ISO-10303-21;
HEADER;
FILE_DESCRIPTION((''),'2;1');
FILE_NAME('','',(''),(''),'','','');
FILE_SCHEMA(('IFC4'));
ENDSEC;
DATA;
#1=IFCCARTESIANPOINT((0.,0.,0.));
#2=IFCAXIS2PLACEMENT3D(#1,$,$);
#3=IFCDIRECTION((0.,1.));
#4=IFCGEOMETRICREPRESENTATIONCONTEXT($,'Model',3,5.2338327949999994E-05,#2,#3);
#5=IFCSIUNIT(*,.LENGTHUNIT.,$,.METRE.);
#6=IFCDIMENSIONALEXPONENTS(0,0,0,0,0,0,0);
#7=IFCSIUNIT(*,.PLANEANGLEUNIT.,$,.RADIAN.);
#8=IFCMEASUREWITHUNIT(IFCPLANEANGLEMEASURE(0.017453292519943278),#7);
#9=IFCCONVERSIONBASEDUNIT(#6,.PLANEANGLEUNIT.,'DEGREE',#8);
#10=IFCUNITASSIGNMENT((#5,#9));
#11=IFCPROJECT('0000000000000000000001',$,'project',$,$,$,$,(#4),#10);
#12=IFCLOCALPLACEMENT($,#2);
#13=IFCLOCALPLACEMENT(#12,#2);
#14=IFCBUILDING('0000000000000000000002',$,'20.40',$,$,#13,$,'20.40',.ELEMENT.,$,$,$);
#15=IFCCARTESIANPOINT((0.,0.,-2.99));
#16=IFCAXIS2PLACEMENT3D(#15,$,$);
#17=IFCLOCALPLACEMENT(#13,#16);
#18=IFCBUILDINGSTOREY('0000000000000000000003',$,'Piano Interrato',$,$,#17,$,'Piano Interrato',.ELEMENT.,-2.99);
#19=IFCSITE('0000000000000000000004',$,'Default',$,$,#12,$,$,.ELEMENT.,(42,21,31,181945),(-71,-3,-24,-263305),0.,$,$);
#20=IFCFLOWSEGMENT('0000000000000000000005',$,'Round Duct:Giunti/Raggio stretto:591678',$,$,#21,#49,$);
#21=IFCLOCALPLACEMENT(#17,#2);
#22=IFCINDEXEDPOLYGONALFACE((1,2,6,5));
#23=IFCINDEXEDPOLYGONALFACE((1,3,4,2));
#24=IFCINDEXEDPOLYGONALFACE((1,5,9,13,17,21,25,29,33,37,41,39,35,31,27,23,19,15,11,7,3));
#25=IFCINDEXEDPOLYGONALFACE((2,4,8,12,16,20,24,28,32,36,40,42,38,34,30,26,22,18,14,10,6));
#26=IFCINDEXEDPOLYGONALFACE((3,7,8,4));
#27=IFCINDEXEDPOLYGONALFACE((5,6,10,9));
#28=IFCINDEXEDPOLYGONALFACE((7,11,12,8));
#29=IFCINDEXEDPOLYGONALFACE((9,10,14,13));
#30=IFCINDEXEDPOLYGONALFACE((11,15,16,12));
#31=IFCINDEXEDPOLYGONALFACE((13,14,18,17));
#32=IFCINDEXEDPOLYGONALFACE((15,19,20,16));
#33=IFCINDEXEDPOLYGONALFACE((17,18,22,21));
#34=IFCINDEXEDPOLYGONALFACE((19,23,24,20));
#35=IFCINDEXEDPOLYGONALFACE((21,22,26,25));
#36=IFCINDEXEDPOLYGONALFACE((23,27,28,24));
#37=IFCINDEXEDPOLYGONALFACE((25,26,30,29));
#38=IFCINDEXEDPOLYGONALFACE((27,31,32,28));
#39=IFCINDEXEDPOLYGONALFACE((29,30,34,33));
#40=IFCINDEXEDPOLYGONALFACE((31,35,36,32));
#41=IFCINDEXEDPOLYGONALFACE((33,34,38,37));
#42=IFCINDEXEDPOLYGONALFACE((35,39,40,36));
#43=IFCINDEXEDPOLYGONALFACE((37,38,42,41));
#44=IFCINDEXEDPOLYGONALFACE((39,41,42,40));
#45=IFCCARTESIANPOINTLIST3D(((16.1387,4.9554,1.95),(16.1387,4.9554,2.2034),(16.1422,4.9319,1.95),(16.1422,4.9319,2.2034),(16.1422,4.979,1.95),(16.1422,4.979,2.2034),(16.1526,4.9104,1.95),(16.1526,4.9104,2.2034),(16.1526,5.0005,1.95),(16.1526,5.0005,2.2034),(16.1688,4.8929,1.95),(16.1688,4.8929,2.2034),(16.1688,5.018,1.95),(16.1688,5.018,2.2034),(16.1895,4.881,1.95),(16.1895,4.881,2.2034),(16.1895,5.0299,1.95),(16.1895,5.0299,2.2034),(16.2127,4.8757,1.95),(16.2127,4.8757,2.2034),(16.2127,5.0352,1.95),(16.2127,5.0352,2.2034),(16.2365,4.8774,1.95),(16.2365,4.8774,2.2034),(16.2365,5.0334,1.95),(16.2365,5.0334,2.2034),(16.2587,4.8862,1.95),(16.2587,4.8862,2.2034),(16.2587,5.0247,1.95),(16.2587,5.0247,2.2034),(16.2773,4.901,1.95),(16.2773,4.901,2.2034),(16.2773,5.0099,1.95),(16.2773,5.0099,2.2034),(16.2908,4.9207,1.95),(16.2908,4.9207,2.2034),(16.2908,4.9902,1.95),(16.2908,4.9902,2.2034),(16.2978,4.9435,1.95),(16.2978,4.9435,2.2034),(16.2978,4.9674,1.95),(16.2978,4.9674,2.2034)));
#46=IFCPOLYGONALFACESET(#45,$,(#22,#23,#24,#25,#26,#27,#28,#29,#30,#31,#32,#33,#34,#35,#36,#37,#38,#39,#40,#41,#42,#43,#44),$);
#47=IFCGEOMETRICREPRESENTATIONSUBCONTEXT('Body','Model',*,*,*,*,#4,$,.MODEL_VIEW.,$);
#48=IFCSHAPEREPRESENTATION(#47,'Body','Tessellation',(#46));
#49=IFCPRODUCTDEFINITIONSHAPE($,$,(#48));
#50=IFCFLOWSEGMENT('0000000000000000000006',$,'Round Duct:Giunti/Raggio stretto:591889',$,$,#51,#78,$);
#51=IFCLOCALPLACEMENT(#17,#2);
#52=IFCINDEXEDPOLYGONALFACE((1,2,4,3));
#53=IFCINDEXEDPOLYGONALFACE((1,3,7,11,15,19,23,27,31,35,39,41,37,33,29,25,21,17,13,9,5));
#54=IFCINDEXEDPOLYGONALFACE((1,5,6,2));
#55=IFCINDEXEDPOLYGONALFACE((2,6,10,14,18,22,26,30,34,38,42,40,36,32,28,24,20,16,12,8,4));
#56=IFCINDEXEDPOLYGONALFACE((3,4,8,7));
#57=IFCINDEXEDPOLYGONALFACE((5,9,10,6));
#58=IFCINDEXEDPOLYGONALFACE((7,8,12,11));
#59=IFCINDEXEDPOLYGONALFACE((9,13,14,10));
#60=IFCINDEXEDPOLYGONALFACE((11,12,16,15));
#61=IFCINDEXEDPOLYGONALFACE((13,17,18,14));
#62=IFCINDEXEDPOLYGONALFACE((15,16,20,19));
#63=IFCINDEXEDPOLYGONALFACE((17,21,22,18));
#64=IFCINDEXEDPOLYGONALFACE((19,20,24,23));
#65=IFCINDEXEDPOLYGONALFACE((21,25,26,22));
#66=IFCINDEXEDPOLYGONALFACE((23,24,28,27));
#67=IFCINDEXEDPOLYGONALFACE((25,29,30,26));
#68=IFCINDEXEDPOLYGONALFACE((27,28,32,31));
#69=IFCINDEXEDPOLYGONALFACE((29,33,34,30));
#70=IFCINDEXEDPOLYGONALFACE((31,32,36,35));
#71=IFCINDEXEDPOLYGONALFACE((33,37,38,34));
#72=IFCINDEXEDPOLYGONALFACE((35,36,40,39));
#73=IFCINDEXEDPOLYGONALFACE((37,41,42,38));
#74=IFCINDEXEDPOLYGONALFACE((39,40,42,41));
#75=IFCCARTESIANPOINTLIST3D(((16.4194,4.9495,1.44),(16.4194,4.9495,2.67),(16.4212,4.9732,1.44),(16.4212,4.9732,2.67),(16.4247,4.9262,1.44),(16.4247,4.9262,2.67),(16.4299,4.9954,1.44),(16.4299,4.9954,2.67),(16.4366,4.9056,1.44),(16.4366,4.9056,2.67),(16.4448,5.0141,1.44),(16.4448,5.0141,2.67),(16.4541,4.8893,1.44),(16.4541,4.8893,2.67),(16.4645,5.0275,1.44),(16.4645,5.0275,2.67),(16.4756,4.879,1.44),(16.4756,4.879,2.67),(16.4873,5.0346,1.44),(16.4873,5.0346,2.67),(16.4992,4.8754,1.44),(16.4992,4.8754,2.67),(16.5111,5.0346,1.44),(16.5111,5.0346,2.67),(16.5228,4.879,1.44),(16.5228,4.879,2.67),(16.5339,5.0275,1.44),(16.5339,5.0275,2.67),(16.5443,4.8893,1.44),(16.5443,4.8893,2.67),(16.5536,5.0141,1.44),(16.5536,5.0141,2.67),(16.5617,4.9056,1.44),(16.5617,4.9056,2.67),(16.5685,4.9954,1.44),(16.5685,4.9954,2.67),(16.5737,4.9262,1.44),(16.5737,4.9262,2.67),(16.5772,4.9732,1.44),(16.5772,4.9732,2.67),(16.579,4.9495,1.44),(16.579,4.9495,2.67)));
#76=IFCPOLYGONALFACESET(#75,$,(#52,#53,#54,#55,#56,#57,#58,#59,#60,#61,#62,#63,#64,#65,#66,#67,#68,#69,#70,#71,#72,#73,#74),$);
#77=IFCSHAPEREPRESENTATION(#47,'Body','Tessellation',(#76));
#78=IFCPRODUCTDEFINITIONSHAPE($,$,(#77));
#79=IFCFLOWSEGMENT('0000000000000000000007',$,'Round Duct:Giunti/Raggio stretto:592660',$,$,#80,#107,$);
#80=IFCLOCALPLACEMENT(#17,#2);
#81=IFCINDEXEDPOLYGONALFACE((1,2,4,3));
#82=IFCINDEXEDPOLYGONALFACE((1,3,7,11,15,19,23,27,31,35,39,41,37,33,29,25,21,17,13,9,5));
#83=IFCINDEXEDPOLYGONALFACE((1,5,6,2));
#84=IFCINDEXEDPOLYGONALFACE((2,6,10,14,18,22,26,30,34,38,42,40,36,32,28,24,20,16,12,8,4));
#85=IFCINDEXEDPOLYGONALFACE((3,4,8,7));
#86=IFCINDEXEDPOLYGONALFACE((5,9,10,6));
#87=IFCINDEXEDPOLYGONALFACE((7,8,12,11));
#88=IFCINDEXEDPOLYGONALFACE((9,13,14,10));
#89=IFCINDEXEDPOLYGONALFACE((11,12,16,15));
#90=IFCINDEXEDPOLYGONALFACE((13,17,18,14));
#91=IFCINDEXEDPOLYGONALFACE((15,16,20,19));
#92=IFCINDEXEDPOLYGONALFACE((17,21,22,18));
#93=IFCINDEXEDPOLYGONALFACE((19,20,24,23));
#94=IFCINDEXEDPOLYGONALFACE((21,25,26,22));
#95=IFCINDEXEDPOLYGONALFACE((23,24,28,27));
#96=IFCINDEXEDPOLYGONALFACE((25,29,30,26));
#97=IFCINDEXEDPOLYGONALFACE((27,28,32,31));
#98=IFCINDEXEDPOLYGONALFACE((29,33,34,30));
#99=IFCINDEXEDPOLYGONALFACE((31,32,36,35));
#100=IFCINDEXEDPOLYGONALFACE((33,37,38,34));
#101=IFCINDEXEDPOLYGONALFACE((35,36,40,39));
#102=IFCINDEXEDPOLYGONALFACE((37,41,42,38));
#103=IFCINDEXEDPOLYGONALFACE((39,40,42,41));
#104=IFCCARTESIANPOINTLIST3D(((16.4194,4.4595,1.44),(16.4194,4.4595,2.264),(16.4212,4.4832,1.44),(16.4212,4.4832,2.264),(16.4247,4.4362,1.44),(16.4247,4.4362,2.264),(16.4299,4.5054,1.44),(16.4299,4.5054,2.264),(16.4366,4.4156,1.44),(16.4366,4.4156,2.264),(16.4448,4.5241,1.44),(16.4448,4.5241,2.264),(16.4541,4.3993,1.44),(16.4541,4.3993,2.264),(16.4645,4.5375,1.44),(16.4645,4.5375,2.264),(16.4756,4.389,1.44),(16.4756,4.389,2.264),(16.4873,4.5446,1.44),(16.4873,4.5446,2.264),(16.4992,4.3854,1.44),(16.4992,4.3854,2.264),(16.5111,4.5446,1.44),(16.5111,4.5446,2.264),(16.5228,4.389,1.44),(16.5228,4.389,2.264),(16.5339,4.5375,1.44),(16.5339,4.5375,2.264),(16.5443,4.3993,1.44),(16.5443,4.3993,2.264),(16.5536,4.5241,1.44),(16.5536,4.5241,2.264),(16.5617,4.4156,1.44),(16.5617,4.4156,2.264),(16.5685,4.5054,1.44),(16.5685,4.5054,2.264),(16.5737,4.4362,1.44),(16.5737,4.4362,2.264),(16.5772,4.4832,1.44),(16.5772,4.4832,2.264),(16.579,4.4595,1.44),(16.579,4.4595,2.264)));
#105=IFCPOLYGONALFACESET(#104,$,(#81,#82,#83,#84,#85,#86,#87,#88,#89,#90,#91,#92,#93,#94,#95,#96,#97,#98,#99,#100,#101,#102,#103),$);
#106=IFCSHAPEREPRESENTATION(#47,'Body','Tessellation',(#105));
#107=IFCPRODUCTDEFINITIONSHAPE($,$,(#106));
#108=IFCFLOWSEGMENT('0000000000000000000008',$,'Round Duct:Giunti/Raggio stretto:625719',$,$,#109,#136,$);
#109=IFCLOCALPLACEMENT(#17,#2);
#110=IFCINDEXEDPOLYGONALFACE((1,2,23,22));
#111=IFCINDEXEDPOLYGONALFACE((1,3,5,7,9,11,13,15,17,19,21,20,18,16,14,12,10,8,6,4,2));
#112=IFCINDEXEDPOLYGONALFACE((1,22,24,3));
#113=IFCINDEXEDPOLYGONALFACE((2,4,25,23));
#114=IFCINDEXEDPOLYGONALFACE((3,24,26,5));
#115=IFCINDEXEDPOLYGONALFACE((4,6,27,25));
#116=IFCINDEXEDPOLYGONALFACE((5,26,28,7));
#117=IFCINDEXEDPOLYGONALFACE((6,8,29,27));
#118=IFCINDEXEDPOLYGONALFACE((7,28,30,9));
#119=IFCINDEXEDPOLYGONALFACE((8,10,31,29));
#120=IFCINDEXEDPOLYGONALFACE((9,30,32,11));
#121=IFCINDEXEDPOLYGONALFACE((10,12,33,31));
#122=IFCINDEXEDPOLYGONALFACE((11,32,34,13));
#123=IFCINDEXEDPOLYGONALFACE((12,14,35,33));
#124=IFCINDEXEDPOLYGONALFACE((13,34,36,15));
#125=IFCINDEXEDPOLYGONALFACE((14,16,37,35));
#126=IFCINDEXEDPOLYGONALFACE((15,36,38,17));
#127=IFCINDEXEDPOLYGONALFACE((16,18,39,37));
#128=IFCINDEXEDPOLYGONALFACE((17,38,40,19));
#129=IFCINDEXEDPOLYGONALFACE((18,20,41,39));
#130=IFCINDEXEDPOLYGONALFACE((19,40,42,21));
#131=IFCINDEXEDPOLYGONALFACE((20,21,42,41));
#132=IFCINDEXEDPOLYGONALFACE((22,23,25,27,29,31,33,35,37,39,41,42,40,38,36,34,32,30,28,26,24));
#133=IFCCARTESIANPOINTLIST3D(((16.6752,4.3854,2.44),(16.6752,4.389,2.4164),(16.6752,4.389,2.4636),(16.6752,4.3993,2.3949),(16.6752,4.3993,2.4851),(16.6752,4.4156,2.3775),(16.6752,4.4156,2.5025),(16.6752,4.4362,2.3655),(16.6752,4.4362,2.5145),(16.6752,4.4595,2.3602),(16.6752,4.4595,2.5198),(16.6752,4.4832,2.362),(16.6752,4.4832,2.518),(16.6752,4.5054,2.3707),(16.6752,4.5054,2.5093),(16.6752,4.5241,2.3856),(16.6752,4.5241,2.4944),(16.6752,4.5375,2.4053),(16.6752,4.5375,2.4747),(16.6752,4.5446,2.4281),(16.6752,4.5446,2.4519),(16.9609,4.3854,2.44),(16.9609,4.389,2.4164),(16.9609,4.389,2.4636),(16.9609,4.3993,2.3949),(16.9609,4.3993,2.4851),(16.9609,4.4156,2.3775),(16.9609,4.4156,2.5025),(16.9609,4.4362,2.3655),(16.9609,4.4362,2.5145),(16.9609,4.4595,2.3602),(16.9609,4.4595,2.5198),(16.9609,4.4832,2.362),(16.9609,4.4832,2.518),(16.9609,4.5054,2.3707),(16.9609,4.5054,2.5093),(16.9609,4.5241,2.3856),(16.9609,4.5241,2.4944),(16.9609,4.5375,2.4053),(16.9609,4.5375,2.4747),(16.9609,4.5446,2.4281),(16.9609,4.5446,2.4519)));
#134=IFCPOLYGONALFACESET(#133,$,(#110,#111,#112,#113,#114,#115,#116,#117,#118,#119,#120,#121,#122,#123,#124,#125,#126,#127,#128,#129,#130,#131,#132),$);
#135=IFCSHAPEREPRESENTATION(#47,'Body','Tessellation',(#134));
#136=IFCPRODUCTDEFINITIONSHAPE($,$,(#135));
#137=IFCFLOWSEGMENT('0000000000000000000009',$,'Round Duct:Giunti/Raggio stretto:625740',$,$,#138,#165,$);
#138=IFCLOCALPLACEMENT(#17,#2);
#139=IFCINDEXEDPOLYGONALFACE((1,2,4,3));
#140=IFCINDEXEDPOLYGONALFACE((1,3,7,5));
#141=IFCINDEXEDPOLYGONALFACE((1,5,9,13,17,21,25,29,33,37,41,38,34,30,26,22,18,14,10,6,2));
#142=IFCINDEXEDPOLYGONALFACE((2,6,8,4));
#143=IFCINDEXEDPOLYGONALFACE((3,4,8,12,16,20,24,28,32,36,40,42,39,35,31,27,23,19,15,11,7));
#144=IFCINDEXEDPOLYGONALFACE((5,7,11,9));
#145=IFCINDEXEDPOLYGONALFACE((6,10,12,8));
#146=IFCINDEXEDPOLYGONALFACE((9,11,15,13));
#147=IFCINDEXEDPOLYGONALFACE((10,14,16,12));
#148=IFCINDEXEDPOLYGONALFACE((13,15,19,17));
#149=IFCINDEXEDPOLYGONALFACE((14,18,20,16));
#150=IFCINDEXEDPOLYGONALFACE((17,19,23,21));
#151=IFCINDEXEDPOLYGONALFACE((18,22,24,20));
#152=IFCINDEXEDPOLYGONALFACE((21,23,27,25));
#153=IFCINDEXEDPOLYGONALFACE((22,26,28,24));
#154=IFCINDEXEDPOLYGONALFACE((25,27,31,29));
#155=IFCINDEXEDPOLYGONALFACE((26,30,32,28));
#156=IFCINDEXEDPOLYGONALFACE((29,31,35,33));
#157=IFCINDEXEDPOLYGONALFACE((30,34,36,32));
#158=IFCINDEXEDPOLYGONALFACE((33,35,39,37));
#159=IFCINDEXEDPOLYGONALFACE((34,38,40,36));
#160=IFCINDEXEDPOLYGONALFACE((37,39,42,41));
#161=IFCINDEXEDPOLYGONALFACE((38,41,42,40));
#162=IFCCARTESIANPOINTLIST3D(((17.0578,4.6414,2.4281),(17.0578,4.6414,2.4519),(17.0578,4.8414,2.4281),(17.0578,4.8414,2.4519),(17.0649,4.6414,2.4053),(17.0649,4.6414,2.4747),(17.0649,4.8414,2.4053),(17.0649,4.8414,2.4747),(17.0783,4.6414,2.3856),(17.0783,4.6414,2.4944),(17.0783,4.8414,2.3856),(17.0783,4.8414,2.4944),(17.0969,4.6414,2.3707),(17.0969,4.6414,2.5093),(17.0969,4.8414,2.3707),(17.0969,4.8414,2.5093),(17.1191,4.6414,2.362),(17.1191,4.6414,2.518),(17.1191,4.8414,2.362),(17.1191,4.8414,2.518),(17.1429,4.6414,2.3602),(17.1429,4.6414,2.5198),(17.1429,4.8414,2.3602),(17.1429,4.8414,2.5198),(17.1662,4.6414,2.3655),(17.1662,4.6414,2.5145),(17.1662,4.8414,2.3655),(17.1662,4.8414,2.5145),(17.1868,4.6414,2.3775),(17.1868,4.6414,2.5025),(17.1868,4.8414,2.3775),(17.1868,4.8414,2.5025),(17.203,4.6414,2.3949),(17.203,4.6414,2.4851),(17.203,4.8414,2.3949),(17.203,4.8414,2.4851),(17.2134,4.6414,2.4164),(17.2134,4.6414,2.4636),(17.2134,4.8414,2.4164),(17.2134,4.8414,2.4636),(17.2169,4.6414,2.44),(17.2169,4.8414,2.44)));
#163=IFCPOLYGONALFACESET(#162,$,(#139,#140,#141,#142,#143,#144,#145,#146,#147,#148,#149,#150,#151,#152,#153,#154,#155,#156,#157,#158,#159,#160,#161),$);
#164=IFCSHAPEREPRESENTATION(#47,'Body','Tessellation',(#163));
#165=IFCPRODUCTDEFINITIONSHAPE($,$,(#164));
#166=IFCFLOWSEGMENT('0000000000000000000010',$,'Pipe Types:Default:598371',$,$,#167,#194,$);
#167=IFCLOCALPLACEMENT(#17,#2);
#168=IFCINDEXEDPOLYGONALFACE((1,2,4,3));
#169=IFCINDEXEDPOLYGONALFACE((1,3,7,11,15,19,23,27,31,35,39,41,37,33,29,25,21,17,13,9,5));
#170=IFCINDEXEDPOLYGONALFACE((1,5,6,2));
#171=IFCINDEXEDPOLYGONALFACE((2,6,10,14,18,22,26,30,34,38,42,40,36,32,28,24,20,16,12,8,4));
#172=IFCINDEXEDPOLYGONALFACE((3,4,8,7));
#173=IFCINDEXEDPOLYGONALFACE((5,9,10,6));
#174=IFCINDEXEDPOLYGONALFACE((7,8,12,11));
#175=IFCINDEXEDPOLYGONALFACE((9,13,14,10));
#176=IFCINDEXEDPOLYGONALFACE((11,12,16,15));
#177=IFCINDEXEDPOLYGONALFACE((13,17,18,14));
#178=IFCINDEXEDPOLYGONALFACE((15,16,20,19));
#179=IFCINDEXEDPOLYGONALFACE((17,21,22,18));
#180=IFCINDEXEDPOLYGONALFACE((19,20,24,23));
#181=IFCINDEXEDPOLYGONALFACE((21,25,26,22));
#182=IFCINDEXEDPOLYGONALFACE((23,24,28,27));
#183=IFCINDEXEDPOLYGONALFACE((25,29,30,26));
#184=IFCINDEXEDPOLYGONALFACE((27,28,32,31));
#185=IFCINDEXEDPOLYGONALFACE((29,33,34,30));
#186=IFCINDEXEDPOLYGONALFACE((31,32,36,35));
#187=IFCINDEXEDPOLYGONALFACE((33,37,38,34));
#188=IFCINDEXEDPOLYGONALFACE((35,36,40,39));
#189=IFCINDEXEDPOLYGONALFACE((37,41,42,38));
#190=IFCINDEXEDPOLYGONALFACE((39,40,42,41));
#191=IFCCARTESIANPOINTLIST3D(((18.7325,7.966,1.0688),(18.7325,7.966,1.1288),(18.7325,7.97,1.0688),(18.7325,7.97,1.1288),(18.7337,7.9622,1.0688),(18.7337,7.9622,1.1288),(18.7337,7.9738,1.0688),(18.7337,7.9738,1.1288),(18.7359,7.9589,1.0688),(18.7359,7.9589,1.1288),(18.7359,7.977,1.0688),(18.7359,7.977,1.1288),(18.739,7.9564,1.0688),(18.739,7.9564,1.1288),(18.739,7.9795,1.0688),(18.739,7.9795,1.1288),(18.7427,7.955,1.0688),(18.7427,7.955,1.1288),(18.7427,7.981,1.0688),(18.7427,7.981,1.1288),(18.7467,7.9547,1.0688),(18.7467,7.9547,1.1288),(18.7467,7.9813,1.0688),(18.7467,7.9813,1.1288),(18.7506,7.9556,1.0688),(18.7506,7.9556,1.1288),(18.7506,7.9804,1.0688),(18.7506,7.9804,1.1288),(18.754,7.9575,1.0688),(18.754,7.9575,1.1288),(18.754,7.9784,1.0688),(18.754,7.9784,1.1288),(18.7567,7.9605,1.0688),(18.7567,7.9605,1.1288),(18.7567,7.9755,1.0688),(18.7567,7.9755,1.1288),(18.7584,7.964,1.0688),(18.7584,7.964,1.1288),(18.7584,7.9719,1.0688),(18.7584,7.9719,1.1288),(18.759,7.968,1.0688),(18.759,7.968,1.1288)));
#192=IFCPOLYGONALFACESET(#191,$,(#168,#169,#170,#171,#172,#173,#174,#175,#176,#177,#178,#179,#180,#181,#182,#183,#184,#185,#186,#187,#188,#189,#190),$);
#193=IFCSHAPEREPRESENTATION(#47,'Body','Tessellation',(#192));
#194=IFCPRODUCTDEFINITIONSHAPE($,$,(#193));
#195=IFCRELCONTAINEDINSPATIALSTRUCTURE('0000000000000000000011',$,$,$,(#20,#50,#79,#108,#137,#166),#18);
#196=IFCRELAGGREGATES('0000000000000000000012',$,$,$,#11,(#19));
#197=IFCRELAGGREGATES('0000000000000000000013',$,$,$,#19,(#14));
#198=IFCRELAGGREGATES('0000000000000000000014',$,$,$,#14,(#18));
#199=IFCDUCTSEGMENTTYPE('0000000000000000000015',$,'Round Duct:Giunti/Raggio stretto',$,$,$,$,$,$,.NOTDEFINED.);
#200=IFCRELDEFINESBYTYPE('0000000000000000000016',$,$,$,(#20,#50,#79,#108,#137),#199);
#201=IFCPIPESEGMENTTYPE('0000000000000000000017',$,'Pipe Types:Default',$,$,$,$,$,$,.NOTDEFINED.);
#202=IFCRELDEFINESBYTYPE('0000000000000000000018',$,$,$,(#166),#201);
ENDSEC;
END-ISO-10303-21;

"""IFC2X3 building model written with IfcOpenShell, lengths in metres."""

from ifc_helpers import new_model, entity, si_unit, converted_unit, direction, frame, frame_2d, origin, origin_2d_with_axis, place, context, subcontext, project, spatial, circle, extrude, type_object, element, save


model = new_model("IFC2X3")

# Units and contexts
model_context = context("Model", 3, precision=5.2338327949999994e-05, world=origin(), true_north=direction((0.0, 1.0)))
body_context = subcontext(model_context, "Body", "Model", "MODEL_VIEW")
ifc_project = project(units=[si_unit("LENGTHUNIT", "METRE"), converted_unit("PLANEANGLEUNIT", "DEGREE", entity("IfcPlaneAngleMeasure", 0.017453292519943278), si_unit("PLANEANGLEUNIT", "RADIAN"), dimensions=[0, 0, 0, 0, 0, 0, 0])], contexts=[model_context])

# Site, building, storey
site_placement = place(None, origin())
site = spatial("IfcSite", under=ifc_project, at=site_placement, Name="Default", CompositionType="ELEMENT", RefLatitude=(42, 21, 31, 181945), RefLongitude=(-71, -3, -24, -263305), RefElevation=0.0)
building_placement = place(site_placement, origin())
building = spatial("IfcBuilding", under=site, at=building_placement, Name="20.40", LongName="20.40", CompositionType="ELEMENT")
storey_placement = place(building_placement, frame((0.0, 0.0, -2.99)))
storey = spatial("IfcBuildingStorey", under=building, at=storey_placement, Name="Piano Interrato", LongName="Piano Interrato", CompositionType="ELEMENT", Elevation=-2.99)

# Flow segments
duct_segment_type_1 = type_object("IfcDuctSegmentType", Name="Round Duct:Giunti/Raggio stretto", PredefinedType="NOTDEFINED")
flow_segment_1_placement = place(storey_placement, origin())
element("IfcFlowSegment", 1, at=flow_segment_1_placement, inside=storey, type_object=duct_segment_type_1, Name="Round Duct:Giunti/Raggio stretto:591678", context=body_context, shape_type="SweptSolid", body=[
    extrude(circle(Radius=0.08, at=frame_2d((0.0, 0.0), x_axis=(1.0, 0.0))), frame((16.2187, 4.9554, 1.95), z_axis=(0.0, 0.0, 1.0), x_axis=(-1.0, 0.0, 0.0)), (0.0, 0.0, 1.0), 0.2534),
])
flow_segment_2_placement = place(storey_placement, origin())
element("IfcFlowSegment", 2, at=flow_segment_2_placement, inside=storey, type_object=duct_segment_type_1, Name="Round Duct:Giunti/Raggio stretto:591889", context=body_context, shape_type="SweptSolid", body=[
    extrude(circle(Radius=0.08, at=origin_2d_with_axis()), frame((16.4992, 4.9554, 1.44), z_axis=(0.0, 0.0, 1.0), x_axis=(0.0, -1.0, 0.0)), (0.0, 0.0, 1.0), 1.23),
])
flow_segment_3_placement = place(storey_placement, origin())
element("IfcFlowSegment", 3, at=flow_segment_3_placement, inside=storey, type_object=duct_segment_type_1, Name="Round Duct:Giunti/Raggio stretto:592660", context=body_context, shape_type="SweptSolid", body=[
    extrude(circle(Radius=0.08, at=origin_2d_with_axis()), frame((16.4992, 4.4654, 1.44), z_axis=(0.0, 0.0, 1.0), x_axis=(0.0, -1.0, 0.0)), (0.0, 0.0, 1.0), 0.824),
])
flow_segment_4_placement = place(storey_placement, origin())
element("IfcFlowSegment", 4, at=flow_segment_4_placement, inside=storey, type_object=duct_segment_type_1, Name="Round Duct:Giunti/Raggio stretto:625719", context=body_context, shape_type="SweptSolid", body=[
    extrude(circle(Radius=0.08, at=frame_2d((0.0, 0.0), x_axis=(1.0, 0.0))), frame((16.6752, 4.4654, 2.44), z_axis=(1.0, 0.0, 0.0), x_axis=(0.0, -1.0, 0.0)), (0.0, 0.0, 1.0), 0.2857),
])
flow_segment_5_placement = place(storey_placement, origin())
element("IfcFlowSegment", 5, at=flow_segment_5_placement, inside=storey, type_object=duct_segment_type_1, Name="Round Duct:Giunti/Raggio stretto:625740", context=body_context, shape_type="SweptSolid", body=[
    extrude(circle(Radius=0.08, at=frame_2d((0.0, 0.0), x_axis=(1.0, 0.0))), frame((17.1369, 4.6414, 2.44), z_axis=(0.0, 1.0, 0.0), x_axis=(1.0, 0.0, 0.0)), (0.0, 0.0, 1.0), 0.1999),
])
pipe_segment_type_1 = type_object("IfcPipeSegmentType", Name="Pipe Types:Default", PredefinedType="NOTDEFINED")
flow_segment_6_placement = place(storey_placement, origin())
element("IfcFlowSegment", 6, at=flow_segment_6_placement, inside=storey, type_object=pipe_segment_type_1, Name="Pipe Types:Default:598371", context=body_context, shape_type="SweptSolid", body=[
    extrude(circle(Radius=0.0133, at=origin_2d_with_axis()), frame((18.7457, 7.968, 1.0688)), (0.0, 0.0, 1.0), 0.06),
])

save(model, "model.ifc")
